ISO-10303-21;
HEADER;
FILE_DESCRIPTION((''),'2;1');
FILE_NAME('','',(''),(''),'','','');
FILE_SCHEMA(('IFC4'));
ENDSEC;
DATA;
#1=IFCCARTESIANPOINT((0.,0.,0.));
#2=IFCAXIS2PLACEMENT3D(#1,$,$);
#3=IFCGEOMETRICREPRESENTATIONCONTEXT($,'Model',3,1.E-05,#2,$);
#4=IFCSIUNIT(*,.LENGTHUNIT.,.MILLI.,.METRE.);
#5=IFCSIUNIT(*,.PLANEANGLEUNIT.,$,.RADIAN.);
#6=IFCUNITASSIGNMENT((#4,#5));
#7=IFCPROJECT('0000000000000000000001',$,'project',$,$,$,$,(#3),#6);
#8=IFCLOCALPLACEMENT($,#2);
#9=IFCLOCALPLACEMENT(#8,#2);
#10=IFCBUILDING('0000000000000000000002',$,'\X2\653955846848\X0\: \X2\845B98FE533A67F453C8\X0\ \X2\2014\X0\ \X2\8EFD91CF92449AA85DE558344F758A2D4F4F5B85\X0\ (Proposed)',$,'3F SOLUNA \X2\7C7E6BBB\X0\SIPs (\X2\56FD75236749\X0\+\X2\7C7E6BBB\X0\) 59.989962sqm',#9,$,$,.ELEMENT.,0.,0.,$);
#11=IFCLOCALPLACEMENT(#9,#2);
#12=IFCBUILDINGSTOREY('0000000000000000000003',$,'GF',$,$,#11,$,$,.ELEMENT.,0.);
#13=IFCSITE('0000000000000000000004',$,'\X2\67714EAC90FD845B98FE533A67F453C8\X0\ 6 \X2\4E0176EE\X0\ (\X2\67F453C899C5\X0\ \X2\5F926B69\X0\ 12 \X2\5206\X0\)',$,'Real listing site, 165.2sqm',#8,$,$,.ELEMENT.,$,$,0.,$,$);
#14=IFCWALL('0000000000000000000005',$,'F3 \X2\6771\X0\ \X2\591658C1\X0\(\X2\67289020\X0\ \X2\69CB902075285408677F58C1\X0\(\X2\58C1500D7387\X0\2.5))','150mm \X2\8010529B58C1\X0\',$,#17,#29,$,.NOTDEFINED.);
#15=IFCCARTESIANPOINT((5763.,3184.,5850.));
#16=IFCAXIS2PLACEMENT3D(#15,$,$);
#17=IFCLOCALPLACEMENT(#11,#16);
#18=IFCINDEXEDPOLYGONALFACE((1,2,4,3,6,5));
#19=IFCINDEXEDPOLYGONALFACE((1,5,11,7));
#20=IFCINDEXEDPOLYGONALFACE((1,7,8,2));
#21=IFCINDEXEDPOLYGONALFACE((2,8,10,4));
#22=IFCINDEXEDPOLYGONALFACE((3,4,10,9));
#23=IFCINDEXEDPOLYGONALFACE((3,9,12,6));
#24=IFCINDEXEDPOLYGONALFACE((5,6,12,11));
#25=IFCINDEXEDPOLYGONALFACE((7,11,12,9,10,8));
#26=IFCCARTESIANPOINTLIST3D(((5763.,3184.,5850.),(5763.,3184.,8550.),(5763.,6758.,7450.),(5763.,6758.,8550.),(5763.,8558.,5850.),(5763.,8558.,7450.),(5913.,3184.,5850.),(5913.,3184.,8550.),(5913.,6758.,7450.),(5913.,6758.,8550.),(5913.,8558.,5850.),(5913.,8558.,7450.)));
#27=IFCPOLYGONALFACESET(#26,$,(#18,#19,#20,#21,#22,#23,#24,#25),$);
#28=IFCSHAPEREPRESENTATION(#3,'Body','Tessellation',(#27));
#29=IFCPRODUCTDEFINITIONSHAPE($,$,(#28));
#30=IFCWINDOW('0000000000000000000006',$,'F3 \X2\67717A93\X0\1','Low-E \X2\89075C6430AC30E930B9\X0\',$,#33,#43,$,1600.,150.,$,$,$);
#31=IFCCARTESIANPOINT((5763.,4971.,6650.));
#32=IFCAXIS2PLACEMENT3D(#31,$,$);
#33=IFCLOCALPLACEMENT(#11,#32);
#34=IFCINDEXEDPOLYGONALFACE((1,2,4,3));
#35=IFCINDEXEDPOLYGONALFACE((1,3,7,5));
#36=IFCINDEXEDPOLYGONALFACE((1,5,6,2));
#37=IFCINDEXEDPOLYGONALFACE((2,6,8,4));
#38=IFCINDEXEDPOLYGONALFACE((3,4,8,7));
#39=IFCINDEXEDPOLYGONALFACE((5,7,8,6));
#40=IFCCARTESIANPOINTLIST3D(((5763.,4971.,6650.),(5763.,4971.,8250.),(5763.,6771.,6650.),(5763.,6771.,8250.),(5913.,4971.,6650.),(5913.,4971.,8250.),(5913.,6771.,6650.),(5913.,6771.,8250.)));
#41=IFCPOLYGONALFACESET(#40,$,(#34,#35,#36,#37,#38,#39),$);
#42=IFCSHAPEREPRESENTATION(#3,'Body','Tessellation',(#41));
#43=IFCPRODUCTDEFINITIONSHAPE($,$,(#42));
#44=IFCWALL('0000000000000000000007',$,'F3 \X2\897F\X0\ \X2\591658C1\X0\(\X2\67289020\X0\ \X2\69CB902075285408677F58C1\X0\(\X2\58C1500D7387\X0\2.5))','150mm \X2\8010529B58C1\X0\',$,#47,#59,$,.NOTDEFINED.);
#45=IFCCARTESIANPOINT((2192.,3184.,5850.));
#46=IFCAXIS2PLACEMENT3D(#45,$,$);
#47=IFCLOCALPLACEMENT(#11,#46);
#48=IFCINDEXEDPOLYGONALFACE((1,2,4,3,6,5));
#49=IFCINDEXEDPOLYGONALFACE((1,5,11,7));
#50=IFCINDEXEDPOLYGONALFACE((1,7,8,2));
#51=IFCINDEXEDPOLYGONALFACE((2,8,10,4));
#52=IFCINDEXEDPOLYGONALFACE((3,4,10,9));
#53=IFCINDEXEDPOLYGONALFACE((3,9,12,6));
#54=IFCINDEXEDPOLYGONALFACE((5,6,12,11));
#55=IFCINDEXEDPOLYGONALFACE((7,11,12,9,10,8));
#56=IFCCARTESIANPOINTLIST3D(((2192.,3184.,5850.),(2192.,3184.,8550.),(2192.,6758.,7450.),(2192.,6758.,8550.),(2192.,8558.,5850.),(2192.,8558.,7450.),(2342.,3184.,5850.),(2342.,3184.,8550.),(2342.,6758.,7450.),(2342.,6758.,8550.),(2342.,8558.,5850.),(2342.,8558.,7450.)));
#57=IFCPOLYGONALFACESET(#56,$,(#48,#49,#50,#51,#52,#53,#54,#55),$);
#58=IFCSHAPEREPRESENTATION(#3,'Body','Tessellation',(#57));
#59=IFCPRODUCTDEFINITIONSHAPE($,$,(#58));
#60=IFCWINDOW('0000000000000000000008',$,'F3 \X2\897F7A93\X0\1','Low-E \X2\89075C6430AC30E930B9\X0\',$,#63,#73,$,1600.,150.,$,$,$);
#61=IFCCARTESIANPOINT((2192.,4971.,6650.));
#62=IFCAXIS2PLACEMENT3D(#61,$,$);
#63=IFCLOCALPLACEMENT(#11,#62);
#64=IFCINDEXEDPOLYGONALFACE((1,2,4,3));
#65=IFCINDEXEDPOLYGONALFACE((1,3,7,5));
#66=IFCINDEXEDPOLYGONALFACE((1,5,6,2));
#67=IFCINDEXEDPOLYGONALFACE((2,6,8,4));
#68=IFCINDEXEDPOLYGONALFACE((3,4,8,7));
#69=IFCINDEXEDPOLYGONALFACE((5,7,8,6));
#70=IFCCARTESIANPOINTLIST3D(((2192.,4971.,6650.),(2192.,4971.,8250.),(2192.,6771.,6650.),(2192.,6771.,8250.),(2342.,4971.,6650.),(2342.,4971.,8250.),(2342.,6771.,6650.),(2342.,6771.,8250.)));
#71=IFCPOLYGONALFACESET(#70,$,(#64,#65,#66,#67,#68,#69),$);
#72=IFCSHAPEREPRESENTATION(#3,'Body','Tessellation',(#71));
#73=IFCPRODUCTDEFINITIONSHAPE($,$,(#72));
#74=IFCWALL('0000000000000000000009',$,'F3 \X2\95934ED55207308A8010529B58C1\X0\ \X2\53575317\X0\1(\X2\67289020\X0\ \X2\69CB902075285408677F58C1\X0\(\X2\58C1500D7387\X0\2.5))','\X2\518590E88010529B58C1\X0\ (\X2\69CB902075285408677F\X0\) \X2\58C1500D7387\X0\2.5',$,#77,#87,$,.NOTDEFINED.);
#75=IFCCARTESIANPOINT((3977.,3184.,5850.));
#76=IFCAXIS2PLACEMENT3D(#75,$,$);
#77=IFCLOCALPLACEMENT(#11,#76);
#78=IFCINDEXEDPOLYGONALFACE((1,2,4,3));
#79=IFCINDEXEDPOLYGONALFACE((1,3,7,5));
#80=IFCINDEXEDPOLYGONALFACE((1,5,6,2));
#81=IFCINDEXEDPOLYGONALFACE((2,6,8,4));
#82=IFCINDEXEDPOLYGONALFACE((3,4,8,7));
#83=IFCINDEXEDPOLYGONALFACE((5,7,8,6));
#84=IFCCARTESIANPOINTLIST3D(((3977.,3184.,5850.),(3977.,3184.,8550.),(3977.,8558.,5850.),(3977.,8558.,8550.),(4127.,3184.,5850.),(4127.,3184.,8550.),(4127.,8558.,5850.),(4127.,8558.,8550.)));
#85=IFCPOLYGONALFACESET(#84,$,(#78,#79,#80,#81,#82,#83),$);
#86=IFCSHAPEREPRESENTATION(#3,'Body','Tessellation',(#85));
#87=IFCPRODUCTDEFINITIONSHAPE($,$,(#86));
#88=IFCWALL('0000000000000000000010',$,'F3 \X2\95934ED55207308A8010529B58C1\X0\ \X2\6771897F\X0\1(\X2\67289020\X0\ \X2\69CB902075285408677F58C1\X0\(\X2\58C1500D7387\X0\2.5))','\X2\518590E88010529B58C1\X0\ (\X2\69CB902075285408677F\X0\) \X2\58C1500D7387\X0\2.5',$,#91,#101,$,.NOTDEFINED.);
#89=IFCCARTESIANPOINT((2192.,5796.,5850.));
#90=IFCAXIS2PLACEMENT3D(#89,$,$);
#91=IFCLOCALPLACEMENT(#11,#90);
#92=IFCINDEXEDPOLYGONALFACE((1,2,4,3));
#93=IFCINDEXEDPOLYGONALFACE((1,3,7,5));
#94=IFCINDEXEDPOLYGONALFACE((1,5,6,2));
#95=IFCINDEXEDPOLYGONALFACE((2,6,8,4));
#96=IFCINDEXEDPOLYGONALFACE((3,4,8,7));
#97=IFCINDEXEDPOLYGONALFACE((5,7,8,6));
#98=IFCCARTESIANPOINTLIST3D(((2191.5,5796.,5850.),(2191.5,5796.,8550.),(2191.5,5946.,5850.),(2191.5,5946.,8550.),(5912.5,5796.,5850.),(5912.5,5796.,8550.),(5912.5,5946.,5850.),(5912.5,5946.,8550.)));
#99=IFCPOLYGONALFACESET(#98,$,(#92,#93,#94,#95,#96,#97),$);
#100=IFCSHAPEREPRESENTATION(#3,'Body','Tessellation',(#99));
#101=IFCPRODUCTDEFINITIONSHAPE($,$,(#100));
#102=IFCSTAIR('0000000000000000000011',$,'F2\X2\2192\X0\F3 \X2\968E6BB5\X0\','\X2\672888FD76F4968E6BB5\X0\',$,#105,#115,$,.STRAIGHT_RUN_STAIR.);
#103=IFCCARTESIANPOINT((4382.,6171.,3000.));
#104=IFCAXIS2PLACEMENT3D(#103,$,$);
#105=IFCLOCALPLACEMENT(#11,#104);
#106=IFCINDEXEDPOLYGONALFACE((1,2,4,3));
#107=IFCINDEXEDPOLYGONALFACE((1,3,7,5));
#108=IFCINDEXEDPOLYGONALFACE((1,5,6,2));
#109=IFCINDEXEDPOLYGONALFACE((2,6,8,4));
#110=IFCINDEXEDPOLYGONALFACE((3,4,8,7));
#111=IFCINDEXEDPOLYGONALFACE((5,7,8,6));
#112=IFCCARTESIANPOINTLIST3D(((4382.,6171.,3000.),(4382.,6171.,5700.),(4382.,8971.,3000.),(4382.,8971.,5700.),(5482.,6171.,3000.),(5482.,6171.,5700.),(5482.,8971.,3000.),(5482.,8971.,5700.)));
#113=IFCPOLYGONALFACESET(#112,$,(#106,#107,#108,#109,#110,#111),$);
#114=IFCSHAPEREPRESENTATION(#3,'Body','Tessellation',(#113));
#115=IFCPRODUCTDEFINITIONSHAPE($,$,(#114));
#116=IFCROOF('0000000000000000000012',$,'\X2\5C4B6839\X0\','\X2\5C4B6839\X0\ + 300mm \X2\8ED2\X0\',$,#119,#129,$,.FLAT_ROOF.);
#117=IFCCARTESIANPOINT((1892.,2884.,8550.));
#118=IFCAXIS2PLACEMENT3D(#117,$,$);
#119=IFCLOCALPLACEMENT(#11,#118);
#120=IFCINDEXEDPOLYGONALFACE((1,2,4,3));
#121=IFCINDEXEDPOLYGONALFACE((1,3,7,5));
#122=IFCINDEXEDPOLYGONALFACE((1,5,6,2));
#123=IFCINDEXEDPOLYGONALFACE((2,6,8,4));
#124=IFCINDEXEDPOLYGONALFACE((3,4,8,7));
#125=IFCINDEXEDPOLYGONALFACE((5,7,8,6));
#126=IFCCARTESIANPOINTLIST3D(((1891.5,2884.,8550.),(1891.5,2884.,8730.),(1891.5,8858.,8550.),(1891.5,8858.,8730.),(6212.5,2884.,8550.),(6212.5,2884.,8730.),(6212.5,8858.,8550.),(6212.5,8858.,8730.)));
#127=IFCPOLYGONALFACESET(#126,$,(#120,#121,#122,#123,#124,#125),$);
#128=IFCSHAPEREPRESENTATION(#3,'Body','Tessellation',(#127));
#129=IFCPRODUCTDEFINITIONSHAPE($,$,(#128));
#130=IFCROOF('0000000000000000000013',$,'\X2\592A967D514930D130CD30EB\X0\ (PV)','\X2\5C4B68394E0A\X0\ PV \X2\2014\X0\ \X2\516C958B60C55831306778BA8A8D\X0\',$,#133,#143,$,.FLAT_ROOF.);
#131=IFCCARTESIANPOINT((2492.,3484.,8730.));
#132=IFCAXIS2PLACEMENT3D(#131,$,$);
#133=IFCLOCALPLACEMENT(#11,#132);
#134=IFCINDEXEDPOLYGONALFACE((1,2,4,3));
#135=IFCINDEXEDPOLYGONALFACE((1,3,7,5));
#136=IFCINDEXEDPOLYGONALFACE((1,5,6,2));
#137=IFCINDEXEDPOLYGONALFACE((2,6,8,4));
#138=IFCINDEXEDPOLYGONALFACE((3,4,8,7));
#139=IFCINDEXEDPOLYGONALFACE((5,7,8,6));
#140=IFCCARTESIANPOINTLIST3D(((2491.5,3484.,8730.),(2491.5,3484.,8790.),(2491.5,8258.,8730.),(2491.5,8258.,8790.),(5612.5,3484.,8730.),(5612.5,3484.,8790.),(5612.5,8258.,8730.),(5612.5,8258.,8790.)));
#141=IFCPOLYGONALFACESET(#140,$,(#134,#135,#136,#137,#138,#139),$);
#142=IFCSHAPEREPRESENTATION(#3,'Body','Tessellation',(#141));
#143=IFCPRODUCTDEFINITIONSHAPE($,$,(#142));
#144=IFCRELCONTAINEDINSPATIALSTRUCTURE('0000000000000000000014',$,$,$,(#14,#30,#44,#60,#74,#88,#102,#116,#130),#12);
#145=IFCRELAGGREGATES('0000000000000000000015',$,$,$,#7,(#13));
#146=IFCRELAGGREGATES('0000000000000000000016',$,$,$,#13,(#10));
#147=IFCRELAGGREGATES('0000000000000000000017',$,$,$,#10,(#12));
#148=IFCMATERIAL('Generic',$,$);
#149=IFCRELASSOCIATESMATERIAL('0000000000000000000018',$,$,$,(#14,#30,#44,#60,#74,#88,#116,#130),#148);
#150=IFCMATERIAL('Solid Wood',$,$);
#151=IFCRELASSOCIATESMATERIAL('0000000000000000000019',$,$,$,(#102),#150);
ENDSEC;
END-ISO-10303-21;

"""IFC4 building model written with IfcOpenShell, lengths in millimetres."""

from ifc_helpers import new_model, si_unit, frame, frame_2d, origin, place, context, project, spatial, rectangle, extrude, material, element, fill, save


model = new_model("IFC4")

# Units and contexts
model_context = context("Model", 3, precision=1e-05, world=origin())
ifc_project = project(units=[si_unit("LENGTHUNIT", "METRE", prefix="MILLI"), si_unit("PLANEANGLEUNIT", "RADIAN")], contexts=[model_context])

# Site, building, storey
site_placement = place(None, origin())
site = spatial("IfcSite", under=ifc_project, at=site_placement, Name="東京都葛飾区柴又 6 丁目 (柴又駅 徒歩 12 分)", ObjectType="Real listing site, 165.2sqm", CompositionType="ELEMENT", RefElevation=0.0)
building_placement = place(site_placement, origin())
building = spatial("IfcBuilding", under=site, at=building_placement, Name="改善案: 葛飾区柴又 — 軽量鉄骨工場併設住宅 (Proposed)", ObjectType="3F SOLUNA 籾殻SIPs (国産杉+籾殻) 59.989962sqm", CompositionType="ELEMENT", ElevationOfRefHeight=0.0, ElevationOfTerrain=0.0)
storey_placement = place(building_placement, origin())
storey = spatial("IfcBuildingStorey", under=building, at=storey_placement, Name="GF", CompositionType="ELEMENT", Elevation=0.0)

# Shared definitions
ifc_material_1 = material(Name="Generic")

# Walls, openings, windows
wall_1_placement = place(storey_placement, frame((5763.0, 3184.0, 5850.0)))
wall_1 = element("IfcWall", 1, at=wall_1_placement, inside=storey, material=ifc_material_1, Name="F3 東 外壁(木造 構造用合板壁(壁倍率2.5))", Description="150mm 耐力壁", PredefinedType="NOTDEFINED", context=model_context, shape_type="SweptSolid", body=[
    extrude(rectangle(XDim=150.0, YDim=5374.0, at=frame_2d((75.0, 2687.0))), frame((5763.0, 3184.0, 5850.0)), (0.0, 0.0, 1.0), 2700.0),
])
opening_1_placement = place(storey_placement, frame((5763.0, 4971.0, 6650.0)))
opening_1 = element("IfcOpeningElement", 2, at=opening_1_placement, cuts=wall_1, PredefinedType="NOTDEFINED", context=model_context, shape_type="SweptSolid", body=[
    extrude(rectangle(XDim=150.0, YDim=1800.0, at=frame_2d((75.0, 900.0))), frame((5763.0, 4971.0, 6650.0)), (0.0, 0.0, 1.0), 1600.0),
])
window_1_placement = place(storey_placement, frame((5763.0, 4971.0, 6650.0)))
window_1 = element("IfcWindow", 3, at=window_1_placement, inside=storey, material=ifc_material_1, Name="F3 東窓1", Description="Low-E 複層ガラス", OverallHeight=1600.0, OverallWidth=150.0, context=model_context, shape_type="SweptSolid", body=[
    extrude(rectangle(XDim=150.0, YDim=1800.0, at=frame_2d((75.0, 900.0))), frame((5763.0, 4971.0, 6650.0)), (0.0, 0.0, 1.0), 1600.0),
])
fill(opening_1, window_1)
wall_2_placement = place(storey_placement, frame((2192.0, 3184.0, 5850.0)))
wall_2 = element("IfcWall", 4, at=wall_2_placement, inside=storey, material=ifc_material_1, Name="F3 西 外壁(木造 構造用合板壁(壁倍率2.5))", Description="150mm 耐力壁", PredefinedType="NOTDEFINED", context=model_context, shape_type="SweptSolid", body=[
    extrude(rectangle(XDim=150.0, YDim=5374.0, at=frame_2d((75.0, 2687.0))), frame((2192.0, 3184.0, 5850.0)), (0.0, 0.0, 1.0), 2700.0),
])
opening_2_placement = place(storey_placement, frame((2192.0, 4971.0, 6650.0)))
opening_2 = element("IfcOpeningElement", 5, at=opening_2_placement, cuts=wall_2, PredefinedType="NOTDEFINED", context=model_context, shape_type="SweptSolid", body=[
    extrude(rectangle(XDim=150.0, YDim=1800.0, at=frame_2d((75.0, 900.0))), frame((2192.0, 4971.0, 6650.0)), (0.0, 0.0, 1.0), 1600.0),
])
window_2_placement = place(storey_placement, frame((2192.0, 4971.0, 6650.0)))
window_2 = element("IfcWindow", 6, at=window_2_placement, inside=storey, material=ifc_material_1, Name="F3 西窓1", Description="Low-E 複層ガラス", OverallHeight=1600.0, OverallWidth=150.0, context=model_context, shape_type="SweptSolid", body=[
    extrude(rectangle(XDim=150.0, YDim=1800.0, at=frame_2d((75.0, 900.0))), frame((2192.0, 4971.0, 6650.0)), (0.0, 0.0, 1.0), 1600.0),
])
fill(opening_2, window_2)

# Walls
wall_3_placement = place(storey_placement, frame((3977.0, 3184.0, 5850.0)))
element("IfcWall", 7, at=wall_3_placement, inside=storey, material=ifc_material_1, Name="F3 間仕切り耐力壁 南北1(木造 構造用合板壁(壁倍率2.5))", Description="内部耐力壁 (構造用合板) 壁倍率2.5", PredefinedType="NOTDEFINED", context=model_context, shape_type="SweptSolid", body=[
    extrude(rectangle(XDim=150.0, YDim=5374.0, at=frame_2d((75.0, 2687.0))), frame((3977.0, 3184.0, 5850.0)), (0.0, 0.0, 1.0), 2700.0),
])
wall_4_placement = place(storey_placement, frame((2192.0, 5796.0, 5850.0)))
element("IfcWall", 8, at=wall_4_placement, inside=storey, material=ifc_material_1, Name="F3 間仕切り耐力壁 東西1(木造 構造用合板壁(壁倍率2.5))", Description="内部耐力壁 (構造用合板) 壁倍率2.5", PredefinedType="NOTDEFINED", context=model_context, shape_type="SweptSolid", body=[
    extrude(rectangle(XDim=3721.0, YDim=150.0, at=frame_2d((1860.0, 75.0))), frame((2192.0, 5796.0, 5850.0)), (0.0, 0.0, 1.0), 2700.0),
])

# Stair
ifc_material_2 = material(Name="Solid Wood")
stair_placement = place(storey_placement, frame((4382.0, 6171.0, 3000.0)))
element("IfcStair", 9, at=stair_placement, inside=storey, material=ifc_material_2, Name="F2→F3 階段", Description="木製直階段", PredefinedType="STRAIGHT_RUN_STAIR", context=model_context, shape_type="SweptSolid", body=[
    extrude(rectangle(XDim=1100.0, YDim=2800.0, at=frame_2d((550.0, 1400.0))), frame((4382.0, 6171.0, 3000.0)), (0.0, 0.0, 1.0), 2700.0),
])

# Roofs
roof_1_placement = place(storey_placement, frame((1892.0, 2884.0, 8550.0)))
element("IfcRoof", 10, at=roof_1_placement, inside=storey, material=ifc_material_1, Name="屋根", Description="屋根 + 300mm 軒", PredefinedType="FLAT_ROOF", context=model_context, shape_type="SweptSolid", body=[
    extrude(rectangle(XDim=4321.0, YDim=5974.0, at=frame_2d((2160.0, 2987.0))), frame((1892.0, 2884.0, 8550.0)), (0.0, 0.0, 1.0), 180.0),
])
roof_2_placement = place(storey_placement, frame((2492.0, 3484.0, 8730.0)))
element("IfcRoof", 11, at=roof_2_placement, inside=storey, material=ifc_material_1, Name="太陽光パネル (PV)", Description="屋根上 PV — 公開情報で確認", PredefinedType="FLAT_ROOF", context=model_context, shape_type="SweptSolid", body=[
    extrude(rectangle(XDim=3121.0, YDim=4774.0, at=frame_2d((1560.0, 2387.0))), frame((2492.0, 3484.0, 8730.0)), (0.0, 0.0, 1.0), 60.0),
])

save(model, "model.ifc")
